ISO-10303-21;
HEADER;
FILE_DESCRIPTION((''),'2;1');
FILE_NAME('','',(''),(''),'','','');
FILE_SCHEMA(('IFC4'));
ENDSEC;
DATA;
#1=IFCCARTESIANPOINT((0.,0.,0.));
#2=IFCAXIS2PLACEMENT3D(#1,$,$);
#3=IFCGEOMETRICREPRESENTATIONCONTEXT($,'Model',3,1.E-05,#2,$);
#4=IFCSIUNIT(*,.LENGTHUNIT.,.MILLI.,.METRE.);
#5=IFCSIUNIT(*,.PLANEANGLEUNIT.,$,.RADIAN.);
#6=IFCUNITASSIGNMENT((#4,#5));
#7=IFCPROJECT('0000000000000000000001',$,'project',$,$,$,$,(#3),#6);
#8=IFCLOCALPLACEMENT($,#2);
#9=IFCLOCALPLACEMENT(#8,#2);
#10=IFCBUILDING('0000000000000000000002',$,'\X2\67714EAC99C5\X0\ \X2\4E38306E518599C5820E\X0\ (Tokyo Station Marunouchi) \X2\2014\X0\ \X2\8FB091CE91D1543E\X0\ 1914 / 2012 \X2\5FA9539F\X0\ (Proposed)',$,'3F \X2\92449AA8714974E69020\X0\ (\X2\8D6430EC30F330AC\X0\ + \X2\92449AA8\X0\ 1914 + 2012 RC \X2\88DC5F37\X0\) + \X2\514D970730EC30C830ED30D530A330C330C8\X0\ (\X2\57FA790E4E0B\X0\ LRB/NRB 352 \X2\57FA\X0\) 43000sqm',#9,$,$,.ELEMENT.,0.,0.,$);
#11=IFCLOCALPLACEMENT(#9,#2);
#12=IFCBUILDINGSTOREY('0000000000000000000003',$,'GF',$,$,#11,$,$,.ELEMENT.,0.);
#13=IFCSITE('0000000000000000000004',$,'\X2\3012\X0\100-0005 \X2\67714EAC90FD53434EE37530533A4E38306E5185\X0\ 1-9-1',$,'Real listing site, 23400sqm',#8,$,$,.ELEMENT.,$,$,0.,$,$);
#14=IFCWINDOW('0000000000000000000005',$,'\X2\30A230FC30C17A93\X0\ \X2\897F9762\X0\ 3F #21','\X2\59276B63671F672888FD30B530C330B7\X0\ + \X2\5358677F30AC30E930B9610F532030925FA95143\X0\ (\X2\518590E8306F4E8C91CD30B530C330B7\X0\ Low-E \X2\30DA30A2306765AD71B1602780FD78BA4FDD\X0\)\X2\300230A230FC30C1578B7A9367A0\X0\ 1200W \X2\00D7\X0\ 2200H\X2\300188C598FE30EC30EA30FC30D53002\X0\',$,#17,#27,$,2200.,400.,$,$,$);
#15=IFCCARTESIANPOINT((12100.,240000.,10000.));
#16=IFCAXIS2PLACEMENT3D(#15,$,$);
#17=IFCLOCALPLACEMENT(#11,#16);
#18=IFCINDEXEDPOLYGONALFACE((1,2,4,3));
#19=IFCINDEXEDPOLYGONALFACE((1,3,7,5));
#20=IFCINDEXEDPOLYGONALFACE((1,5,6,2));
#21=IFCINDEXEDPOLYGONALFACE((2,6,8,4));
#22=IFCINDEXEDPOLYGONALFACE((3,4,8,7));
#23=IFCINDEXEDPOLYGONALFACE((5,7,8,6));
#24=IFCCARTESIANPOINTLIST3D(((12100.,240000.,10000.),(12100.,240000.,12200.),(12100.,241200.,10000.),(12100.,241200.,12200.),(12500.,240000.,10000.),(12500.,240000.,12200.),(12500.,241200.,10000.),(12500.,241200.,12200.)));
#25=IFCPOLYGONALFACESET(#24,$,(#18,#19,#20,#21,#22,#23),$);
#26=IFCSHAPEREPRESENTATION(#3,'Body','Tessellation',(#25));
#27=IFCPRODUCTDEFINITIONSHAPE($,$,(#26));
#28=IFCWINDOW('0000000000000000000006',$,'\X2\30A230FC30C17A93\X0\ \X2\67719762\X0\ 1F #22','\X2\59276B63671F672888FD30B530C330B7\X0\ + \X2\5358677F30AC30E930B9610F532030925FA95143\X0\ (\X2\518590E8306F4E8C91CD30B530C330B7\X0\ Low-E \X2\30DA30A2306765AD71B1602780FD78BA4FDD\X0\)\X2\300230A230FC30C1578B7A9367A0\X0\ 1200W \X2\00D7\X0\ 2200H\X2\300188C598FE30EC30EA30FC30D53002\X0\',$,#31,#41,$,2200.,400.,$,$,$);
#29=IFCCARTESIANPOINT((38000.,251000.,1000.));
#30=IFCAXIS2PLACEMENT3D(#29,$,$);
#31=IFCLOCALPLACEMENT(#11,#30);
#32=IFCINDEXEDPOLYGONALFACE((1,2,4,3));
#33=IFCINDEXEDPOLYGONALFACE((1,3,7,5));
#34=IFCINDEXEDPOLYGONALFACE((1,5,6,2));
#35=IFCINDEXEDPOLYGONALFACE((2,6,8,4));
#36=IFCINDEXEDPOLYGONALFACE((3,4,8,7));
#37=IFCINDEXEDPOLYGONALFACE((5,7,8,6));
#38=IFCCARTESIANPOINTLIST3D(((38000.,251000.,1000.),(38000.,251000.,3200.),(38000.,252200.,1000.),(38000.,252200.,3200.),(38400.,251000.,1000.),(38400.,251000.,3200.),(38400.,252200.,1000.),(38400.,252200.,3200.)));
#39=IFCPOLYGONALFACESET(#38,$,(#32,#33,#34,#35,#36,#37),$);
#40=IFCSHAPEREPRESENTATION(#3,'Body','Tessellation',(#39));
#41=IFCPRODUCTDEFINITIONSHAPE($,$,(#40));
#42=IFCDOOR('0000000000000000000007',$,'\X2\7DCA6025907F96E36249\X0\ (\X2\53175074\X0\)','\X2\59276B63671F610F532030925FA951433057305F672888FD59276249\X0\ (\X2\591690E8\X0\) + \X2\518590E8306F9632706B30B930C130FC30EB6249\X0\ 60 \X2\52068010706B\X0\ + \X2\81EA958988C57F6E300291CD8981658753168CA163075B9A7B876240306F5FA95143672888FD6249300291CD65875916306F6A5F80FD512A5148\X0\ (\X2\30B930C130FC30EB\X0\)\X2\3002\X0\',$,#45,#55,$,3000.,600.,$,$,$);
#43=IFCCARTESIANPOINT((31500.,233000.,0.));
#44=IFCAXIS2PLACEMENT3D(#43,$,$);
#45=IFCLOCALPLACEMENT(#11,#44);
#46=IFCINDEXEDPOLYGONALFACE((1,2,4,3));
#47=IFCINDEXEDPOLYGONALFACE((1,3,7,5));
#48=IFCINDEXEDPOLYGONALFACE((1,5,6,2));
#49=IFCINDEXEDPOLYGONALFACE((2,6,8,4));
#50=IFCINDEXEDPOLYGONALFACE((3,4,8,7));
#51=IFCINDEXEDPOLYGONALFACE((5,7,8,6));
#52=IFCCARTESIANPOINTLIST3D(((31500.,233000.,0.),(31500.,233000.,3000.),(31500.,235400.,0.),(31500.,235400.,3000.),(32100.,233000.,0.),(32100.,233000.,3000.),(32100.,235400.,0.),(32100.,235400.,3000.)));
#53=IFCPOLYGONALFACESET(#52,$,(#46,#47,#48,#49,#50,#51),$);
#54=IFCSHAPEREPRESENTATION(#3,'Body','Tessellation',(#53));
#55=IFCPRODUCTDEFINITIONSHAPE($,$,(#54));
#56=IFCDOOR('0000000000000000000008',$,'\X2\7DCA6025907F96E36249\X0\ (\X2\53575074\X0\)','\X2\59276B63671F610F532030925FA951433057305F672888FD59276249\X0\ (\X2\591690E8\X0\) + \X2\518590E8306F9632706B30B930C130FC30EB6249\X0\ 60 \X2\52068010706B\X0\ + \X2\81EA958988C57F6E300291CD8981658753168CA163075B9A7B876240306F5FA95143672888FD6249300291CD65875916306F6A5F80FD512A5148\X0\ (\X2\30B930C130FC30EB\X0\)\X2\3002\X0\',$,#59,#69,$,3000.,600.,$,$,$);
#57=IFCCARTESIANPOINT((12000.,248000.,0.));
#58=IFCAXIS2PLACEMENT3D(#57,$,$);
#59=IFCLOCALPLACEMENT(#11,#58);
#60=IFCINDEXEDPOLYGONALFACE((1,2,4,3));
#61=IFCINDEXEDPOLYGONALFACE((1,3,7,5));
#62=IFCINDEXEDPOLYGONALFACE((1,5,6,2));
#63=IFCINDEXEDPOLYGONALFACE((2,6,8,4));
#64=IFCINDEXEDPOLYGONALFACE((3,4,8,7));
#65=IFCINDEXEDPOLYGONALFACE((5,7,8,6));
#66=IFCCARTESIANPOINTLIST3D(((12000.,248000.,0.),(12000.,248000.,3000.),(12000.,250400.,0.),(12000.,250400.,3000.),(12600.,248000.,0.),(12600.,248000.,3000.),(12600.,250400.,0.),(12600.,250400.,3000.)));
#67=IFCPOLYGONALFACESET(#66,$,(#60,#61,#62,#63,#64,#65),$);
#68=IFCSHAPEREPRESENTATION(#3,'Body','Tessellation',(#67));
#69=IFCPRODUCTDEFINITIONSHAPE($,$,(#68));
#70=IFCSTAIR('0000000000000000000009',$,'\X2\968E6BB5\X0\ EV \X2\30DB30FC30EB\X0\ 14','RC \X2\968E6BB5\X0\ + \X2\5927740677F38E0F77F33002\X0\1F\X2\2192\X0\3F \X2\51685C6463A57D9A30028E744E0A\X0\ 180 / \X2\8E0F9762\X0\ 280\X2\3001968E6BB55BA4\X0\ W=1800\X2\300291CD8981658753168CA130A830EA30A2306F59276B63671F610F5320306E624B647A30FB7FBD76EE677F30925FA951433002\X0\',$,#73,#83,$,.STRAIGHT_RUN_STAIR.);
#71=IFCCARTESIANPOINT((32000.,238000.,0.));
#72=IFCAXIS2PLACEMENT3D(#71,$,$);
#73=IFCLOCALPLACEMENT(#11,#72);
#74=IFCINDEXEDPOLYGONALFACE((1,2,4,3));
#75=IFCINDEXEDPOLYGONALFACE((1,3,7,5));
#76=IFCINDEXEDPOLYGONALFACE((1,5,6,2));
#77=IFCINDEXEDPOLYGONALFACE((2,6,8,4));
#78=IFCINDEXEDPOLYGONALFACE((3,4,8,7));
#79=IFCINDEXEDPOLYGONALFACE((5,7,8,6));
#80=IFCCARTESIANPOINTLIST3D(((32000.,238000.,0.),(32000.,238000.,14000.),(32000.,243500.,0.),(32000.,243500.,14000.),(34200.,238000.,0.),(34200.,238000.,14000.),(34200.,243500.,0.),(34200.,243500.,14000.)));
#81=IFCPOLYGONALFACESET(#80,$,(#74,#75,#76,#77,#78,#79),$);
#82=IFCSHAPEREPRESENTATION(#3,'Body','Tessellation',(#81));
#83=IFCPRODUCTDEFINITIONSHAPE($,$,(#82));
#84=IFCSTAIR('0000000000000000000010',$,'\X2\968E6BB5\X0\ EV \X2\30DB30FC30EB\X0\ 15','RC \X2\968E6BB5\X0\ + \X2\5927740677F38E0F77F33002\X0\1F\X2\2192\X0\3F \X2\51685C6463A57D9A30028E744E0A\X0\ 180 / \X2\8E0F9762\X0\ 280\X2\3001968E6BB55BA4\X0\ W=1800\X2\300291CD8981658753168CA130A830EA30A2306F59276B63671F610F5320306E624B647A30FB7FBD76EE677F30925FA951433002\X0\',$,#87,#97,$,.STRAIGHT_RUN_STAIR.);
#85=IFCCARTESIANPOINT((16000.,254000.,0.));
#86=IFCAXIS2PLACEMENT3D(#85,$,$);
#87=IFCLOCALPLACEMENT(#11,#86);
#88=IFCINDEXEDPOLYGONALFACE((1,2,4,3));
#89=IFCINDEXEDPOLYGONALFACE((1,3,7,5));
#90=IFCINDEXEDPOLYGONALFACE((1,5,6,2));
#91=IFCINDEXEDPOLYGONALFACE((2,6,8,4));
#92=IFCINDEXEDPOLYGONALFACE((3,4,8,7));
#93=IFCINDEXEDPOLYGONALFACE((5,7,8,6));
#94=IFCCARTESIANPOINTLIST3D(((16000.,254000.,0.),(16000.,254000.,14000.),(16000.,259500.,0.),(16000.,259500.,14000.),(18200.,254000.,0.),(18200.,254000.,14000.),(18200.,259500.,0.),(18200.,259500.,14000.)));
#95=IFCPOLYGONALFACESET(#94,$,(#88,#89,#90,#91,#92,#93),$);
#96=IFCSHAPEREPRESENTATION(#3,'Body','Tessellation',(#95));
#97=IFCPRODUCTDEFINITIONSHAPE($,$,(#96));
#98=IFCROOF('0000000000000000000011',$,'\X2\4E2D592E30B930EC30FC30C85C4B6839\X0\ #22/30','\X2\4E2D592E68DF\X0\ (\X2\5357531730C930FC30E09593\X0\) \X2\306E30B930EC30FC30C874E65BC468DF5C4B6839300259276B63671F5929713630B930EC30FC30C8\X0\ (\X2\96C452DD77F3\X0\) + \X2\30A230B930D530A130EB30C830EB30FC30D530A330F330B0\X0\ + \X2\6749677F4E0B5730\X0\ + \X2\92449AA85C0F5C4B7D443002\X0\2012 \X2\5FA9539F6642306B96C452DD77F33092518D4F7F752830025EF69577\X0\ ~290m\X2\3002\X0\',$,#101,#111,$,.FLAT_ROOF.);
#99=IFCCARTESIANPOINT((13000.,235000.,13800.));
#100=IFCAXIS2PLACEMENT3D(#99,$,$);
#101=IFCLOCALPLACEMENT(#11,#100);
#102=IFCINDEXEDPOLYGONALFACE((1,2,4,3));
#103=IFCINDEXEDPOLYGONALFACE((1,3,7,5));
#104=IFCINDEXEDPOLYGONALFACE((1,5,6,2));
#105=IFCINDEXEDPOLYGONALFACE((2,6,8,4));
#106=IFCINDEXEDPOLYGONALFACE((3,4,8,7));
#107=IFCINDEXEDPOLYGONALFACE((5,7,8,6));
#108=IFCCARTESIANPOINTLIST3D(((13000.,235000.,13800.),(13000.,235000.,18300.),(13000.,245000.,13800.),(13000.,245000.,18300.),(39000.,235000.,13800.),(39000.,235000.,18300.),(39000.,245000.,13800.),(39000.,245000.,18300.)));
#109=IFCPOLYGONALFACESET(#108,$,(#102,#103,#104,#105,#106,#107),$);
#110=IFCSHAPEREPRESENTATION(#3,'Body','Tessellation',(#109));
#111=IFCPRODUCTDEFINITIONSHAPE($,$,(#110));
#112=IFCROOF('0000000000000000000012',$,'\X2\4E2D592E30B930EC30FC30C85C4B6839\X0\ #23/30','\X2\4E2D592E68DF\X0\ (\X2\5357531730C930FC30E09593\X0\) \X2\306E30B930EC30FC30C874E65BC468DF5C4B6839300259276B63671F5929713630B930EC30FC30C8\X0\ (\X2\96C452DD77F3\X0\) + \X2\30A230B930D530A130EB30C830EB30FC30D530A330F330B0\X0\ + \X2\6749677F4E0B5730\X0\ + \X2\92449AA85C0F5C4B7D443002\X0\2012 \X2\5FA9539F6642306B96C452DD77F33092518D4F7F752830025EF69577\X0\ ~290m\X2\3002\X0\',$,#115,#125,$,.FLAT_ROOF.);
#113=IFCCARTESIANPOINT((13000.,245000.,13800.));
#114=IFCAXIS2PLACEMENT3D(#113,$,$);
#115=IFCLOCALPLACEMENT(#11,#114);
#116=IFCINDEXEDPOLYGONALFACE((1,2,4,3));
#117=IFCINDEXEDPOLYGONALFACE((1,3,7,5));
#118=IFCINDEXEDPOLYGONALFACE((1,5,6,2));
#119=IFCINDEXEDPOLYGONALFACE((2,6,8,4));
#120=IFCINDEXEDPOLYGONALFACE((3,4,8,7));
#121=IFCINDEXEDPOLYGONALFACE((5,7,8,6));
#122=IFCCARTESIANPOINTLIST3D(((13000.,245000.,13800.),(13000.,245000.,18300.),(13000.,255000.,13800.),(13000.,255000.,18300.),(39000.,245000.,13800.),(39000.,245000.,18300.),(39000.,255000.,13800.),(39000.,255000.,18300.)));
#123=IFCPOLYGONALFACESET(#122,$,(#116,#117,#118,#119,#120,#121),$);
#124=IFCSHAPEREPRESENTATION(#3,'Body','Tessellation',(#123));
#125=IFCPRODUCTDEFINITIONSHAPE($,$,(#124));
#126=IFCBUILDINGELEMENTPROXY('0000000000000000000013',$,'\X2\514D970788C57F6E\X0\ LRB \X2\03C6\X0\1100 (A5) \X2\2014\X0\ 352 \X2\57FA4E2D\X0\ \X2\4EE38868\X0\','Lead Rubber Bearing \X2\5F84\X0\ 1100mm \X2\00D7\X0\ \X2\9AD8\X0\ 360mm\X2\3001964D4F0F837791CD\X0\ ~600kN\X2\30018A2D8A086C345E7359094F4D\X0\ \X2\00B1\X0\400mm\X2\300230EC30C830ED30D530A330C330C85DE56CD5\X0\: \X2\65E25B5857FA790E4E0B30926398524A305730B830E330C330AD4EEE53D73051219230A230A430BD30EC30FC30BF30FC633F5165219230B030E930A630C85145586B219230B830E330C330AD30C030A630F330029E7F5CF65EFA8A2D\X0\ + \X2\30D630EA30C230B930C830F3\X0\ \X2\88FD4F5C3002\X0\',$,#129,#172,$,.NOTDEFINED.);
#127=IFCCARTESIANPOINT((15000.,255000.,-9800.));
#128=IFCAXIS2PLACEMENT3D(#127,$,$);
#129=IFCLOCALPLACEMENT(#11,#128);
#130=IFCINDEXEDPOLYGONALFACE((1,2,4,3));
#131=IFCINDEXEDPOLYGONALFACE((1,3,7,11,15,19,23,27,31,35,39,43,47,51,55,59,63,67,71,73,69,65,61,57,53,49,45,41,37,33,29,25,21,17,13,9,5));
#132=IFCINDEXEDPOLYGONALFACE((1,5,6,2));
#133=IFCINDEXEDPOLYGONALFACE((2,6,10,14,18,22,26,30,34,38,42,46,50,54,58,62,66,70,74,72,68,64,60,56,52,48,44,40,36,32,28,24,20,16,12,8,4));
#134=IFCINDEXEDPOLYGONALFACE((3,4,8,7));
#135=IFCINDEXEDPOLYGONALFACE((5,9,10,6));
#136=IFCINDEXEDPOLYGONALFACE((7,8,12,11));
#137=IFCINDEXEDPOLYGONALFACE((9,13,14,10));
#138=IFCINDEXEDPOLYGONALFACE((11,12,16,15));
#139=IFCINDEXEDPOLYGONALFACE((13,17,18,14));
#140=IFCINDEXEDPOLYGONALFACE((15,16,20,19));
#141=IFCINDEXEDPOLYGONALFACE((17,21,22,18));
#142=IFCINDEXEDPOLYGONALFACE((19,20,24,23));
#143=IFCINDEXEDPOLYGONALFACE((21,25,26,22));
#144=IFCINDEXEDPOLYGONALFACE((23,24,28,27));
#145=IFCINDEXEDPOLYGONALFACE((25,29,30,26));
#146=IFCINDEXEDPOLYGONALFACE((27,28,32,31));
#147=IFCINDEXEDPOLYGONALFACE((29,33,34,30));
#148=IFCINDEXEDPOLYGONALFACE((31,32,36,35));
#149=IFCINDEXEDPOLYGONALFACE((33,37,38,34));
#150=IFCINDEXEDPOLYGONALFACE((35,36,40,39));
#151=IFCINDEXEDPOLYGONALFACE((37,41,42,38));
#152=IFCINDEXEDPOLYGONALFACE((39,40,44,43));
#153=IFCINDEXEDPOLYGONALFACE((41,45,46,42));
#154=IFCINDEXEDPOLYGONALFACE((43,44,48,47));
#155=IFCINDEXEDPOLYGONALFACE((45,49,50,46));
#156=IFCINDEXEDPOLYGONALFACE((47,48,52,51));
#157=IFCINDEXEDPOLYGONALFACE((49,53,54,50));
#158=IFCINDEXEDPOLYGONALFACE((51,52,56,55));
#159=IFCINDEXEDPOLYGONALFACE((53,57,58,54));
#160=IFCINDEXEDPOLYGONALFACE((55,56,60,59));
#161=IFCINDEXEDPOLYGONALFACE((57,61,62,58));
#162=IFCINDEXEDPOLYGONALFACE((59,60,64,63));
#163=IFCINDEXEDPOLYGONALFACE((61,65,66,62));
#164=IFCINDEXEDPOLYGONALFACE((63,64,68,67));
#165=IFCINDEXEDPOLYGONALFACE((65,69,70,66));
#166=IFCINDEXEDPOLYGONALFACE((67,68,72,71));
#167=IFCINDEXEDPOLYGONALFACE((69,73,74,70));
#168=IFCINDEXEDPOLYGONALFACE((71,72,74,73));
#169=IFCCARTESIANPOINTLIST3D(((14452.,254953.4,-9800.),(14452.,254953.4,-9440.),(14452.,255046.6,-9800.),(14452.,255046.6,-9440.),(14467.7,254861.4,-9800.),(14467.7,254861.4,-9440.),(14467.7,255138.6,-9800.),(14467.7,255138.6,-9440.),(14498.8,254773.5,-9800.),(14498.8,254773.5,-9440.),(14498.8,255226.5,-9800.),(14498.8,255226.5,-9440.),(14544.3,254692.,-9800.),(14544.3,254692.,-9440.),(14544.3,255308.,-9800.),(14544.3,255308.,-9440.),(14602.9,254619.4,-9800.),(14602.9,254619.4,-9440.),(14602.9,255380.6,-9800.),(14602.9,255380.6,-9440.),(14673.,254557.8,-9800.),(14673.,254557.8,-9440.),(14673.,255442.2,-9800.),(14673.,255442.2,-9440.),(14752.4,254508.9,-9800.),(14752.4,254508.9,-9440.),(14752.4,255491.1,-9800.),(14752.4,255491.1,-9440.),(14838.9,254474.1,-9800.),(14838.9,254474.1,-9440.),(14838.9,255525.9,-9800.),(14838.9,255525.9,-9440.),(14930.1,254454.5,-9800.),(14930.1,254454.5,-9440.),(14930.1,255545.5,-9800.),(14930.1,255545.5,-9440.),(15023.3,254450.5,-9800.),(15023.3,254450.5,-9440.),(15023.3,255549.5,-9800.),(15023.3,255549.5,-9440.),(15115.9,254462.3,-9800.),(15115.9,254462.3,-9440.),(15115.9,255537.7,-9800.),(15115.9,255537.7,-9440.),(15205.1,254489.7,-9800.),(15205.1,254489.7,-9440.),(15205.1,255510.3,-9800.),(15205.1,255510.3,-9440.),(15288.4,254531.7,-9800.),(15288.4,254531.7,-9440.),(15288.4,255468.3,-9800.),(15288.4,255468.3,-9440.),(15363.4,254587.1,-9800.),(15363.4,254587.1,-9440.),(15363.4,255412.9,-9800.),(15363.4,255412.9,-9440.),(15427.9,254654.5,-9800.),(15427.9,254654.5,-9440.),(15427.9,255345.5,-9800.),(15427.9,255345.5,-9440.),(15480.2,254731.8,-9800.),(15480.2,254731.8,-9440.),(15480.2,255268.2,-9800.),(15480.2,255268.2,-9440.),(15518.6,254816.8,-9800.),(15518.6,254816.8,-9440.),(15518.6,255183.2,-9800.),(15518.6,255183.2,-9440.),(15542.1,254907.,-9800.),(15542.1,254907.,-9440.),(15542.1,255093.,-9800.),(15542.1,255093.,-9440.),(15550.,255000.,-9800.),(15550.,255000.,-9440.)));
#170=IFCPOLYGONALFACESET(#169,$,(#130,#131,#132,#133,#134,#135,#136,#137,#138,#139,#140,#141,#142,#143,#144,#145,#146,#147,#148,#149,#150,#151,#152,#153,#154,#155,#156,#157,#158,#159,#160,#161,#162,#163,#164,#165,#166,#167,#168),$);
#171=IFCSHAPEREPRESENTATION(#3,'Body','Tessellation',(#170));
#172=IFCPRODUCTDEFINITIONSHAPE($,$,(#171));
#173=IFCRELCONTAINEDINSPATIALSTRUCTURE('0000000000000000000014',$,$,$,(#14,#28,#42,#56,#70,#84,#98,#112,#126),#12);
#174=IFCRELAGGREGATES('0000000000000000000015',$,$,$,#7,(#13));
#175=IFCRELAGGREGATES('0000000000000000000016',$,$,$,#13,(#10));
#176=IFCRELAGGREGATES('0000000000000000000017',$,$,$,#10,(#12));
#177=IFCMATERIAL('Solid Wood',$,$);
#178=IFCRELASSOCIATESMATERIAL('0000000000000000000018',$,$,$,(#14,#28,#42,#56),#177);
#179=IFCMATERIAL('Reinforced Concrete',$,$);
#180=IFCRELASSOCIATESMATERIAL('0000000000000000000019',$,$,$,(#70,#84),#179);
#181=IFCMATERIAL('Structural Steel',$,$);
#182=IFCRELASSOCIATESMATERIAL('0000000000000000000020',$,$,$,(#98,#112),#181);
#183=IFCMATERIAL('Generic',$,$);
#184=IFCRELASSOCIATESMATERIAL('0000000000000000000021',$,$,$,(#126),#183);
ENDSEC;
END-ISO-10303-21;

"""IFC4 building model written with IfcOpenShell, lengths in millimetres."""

from ifc_helpers import new_model, si_unit, frame, frame_2d, origin, origin_2d, place, context, project, spatial, rectangle, circle, extrude, material, element, save


model = new_model("IFC4")

# Units and contexts
model_context = context("Model", 3, precision=1e-05, world=origin())
ifc_project = project(units=[si_unit("LENGTHUNIT", "METRE", prefix="MILLI"), si_unit("PLANEANGLEUNIT", "RADIAN")], contexts=[model_context])

# Site, building, storey
site_placement = place(None, origin())
site = spatial("IfcSite", under=ifc_project, at=site_placement, Name="〒100-0005 東京都千代田区丸の内 1-9-1", ObjectType="Real listing site, 23400sqm", CompositionType="ELEMENT", RefElevation=0.0)
building_placement = place(site_placement, origin())
building = spatial("IfcBuilding", under=site, at=building_placement, Name="東京駅 丸の内駅舎 (Tokyo Station Marunouchi) — 辰野金吾 1914 / 2012 復原 (Proposed)", ObjectType="3F 鉄骨煉瓦造 (赤レンガ + 鉄骨 1914 + 2012 RC 補強) + 免震レトロフィット (基礎下 LRB/NRB 352 基) 43000sqm", CompositionType="ELEMENT", ElevationOfRefHeight=0.0, ElevationOfTerrain=0.0)
storey_placement = place(building_placement, origin())
storey = spatial("IfcBuildingStorey", under=building, at=storey_placement, Name="GF", CompositionType="ELEMENT", Elevation=0.0)

# Shared definitions
ifc_material_1 = material(Name="Structural Steel")

# Shared definitions
ifc_material_2 = material(Name="Reinforced Concrete")
ifc_material_3 = material(Name="Generic")

# Windows
ifc_material_4 = material(Name="Solid Wood")
window_1_placement = place(storey_placement, frame((12100.0, 240000.0, 10000.0)))
element("IfcWindow", 1, at=window_1_placement, inside=storey, material=ifc_material_4, Name="アーチ窓 西面 3F #21", Description="大正期木製サッシ + 単板ガラス意匠を復元 (内部は二重サッシ Low-E ペアで断熱性能確保)。アーチ型窓枠 1200W × 2200H、装飾レリーフ。", OverallHeight=2200.0, OverallWidth=400.0, context=model_context, shape_type="SweptSolid", body=[
    extrude(rectangle(XDim=400.0, YDim=1200.0, at=frame_2d((200.0, 600.0))), frame((12100.0, 240000.0, 10000.0)), (0.0, 0.0, 1.0), 2200.0),
])
window_2_placement = place(storey_placement, frame((38000.0, 251000.0, 1000.0)))
element("IfcWindow", 2, at=window_2_placement, inside=storey, material=ifc_material_4, Name="アーチ窓 東面 1F #22", Description="大正期木製サッシ + 単板ガラス意匠を復元 (内部は二重サッシ Low-E ペアで断熱性能確保)。アーチ型窓枠 1200W × 2200H、装飾レリーフ。", OverallHeight=2200.0, OverallWidth=400.0, context=model_context, shape_type="SweptSolid", body=[
    extrude(rectangle(XDim=400.0, YDim=1200.0, at=frame_2d((200.0, 600.0))), frame((38000.0, 251000.0, 1000.0)), (0.0, 0.0, 1.0), 2200.0),
])

# Doors
door_1_placement = place(storey_placement, frame((31500.0, 233000.0, 0.0)))
element("IfcDoor", 3, at=door_1_placement, inside=storey, material=ifc_material_4, Name="緊急避難扉 (北側)", Description="大正期意匠を復元した木製大扉 (外部) + 内部は防火スチール扉 60 分耐火 + 自閉装置。重要文化財指定箇所は復元木製扉。重文外は機能優先 (スチール)。", OverallHeight=3000.0, OverallWidth=600.0, context=model_context, shape_type="SweptSolid", body=[
    extrude(rectangle(XDim=600.0, YDim=2400.0, at=frame_2d((300.0, 1200.0))), frame((31500.0, 233000.0, 0.0)), (0.0, 0.0, 1.0), 3000.0),
])
door_2_placement = place(storey_placement, frame((12000.0, 248000.0, 0.0)))
element("IfcDoor", 4, at=door_2_placement, inside=storey, material=ifc_material_4, Name="緊急避難扉 (南側)", Description="大正期意匠を復元した木製大扉 (外部) + 内部は防火スチール扉 60 分耐火 + 自閉装置。重要文化財指定箇所は復元木製扉。重文外は機能優先 (スチール)。", OverallHeight=3000.0, OverallWidth=600.0, context=model_context, shape_type="SweptSolid", body=[
    extrude(rectangle(XDim=600.0, YDim=2400.0, at=frame_2d((300.0, 1200.0))), frame((12000.0, 248000.0, 0.0)), (0.0, 0.0, 1.0), 3000.0),
])

# Stairs
stair_1_placement = place(storey_placement, frame((32000.0, 238000.0, 0.0)))
element("IfcStair", 5, at=stair_1_placement, inside=storey, material=ifc_material_2, Name="階段 EV ホール 14", Description="RC 階段 + 大理石踏石。1F→3F 全層接続。蹴上 180 / 踏面 280、階段室 W=1800。重要文化財エリアは大正期意匠の手摺・羽目板を復元。", PredefinedType="STRAIGHT_RUN_STAIR", context=model_context, shape_type="SweptSolid", body=[
    extrude(rectangle(XDim=2200.0, YDim=5500.0, at=frame_2d((1100.0, 2750.0))), frame((32000.0, 238000.0, 0.0)), (0.0, 0.0, 1.0), 14000.0),
])
stair_2_placement = place(storey_placement, frame((16000.0, 254000.0, 0.0)))
element("IfcStair", 6, at=stair_2_placement, inside=storey, material=ifc_material_2, Name="階段 EV ホール 15", Description="RC 階段 + 大理石踏石。1F→3F 全層接続。蹴上 180 / 踏面 280、階段室 W=1800。重要文化財エリアは大正期意匠の手摺・羽目板を復元。", PredefinedType="STRAIGHT_RUN_STAIR", context=model_context, shape_type="SweptSolid", body=[
    extrude(rectangle(XDim=2200.0, YDim=5500.0, at=frame_2d((1100.0, 2750.0))), frame((16000.0, 254000.0, 0.0)), (0.0, 0.0, 1.0), 14000.0),
])

# Roofs
roof_1_placement = place(storey_placement, frame((13000.0, 235000.0, 13800.0)))
element("IfcRoof", 7, at=roof_1_placement, inside=storey, material=ifc_material_1, Name="中央スレート屋根 #22/30", Description="中央棟 (南北ドーム間) のスレート瓦寄棟屋根。大正期天然スレート (雄勝石) + アスファルトルーフィング + 杉板下地 + 鉄骨小屋組。2012 復原時に雄勝石を再使用。延長 ~290m。", PredefinedType="FLAT_ROOF", context=model_context, shape_type="SweptSolid", body=[
    extrude(rectangle(XDim=26000.0, YDim=10000.0, at=frame_2d((13000.0, 5000.0))), frame((13000.0, 235000.0, 13800.0)), (0.0, 0.0, 1.0), 4500.0),
])
roof_2_placement = place(storey_placement, frame((13000.0, 245000.0, 13800.0)))
element("IfcRoof", 8, at=roof_2_placement, inside=storey, material=ifc_material_1, Name="中央スレート屋根 #23/30", Description="中央棟 (南北ドーム間) のスレート瓦寄棟屋根。大正期天然スレート (雄勝石) + アスファルトルーフィング + 杉板下地 + 鉄骨小屋組。2012 復原時に雄勝石を再使用。延長 ~290m。", PredefinedType="FLAT_ROOF", context=model_context, shape_type="SweptSolid", body=[
    extrude(rectangle(XDim=26000.0, YDim=10000.0, at=frame_2d((13000.0, 5000.0))), frame((13000.0, 245000.0, 13800.0)), (0.0, 0.0, 1.0), 4500.0),
])

# Building element proxy
proxy_1_placement = place(storey_placement, frame((15000.0, 255000.0, -9800.0)))
element("IfcBuildingElementProxy", 9, at=proxy_1_placement, inside=storey, material=ifc_material_3, Name="免震装置 LRB φ1100 (A5) — 352 基中 代表", Description="Lead Rubber Bearing 径 1100mm × 高 360mm、降伏荷重 ~600kN、設計水平変位 ±400mm。レトロフィット工法: 既存基礎下を掘削しジャッキ仮受け→アイソレーター挿入→グラウト充填→ジャッキダウン。鹿島建設 + ブリヂストン 製作。", PredefinedType="NOTDEFINED", context=model_context, shape_type="SweptSolid", body=[
    extrude(circle(Radius=550.0, at=origin_2d()), frame((15000.0, 255000.0, -9800.0)), (0.0, 0.0, 1.0), 360.0),
])

save(model, "model.ifc")
